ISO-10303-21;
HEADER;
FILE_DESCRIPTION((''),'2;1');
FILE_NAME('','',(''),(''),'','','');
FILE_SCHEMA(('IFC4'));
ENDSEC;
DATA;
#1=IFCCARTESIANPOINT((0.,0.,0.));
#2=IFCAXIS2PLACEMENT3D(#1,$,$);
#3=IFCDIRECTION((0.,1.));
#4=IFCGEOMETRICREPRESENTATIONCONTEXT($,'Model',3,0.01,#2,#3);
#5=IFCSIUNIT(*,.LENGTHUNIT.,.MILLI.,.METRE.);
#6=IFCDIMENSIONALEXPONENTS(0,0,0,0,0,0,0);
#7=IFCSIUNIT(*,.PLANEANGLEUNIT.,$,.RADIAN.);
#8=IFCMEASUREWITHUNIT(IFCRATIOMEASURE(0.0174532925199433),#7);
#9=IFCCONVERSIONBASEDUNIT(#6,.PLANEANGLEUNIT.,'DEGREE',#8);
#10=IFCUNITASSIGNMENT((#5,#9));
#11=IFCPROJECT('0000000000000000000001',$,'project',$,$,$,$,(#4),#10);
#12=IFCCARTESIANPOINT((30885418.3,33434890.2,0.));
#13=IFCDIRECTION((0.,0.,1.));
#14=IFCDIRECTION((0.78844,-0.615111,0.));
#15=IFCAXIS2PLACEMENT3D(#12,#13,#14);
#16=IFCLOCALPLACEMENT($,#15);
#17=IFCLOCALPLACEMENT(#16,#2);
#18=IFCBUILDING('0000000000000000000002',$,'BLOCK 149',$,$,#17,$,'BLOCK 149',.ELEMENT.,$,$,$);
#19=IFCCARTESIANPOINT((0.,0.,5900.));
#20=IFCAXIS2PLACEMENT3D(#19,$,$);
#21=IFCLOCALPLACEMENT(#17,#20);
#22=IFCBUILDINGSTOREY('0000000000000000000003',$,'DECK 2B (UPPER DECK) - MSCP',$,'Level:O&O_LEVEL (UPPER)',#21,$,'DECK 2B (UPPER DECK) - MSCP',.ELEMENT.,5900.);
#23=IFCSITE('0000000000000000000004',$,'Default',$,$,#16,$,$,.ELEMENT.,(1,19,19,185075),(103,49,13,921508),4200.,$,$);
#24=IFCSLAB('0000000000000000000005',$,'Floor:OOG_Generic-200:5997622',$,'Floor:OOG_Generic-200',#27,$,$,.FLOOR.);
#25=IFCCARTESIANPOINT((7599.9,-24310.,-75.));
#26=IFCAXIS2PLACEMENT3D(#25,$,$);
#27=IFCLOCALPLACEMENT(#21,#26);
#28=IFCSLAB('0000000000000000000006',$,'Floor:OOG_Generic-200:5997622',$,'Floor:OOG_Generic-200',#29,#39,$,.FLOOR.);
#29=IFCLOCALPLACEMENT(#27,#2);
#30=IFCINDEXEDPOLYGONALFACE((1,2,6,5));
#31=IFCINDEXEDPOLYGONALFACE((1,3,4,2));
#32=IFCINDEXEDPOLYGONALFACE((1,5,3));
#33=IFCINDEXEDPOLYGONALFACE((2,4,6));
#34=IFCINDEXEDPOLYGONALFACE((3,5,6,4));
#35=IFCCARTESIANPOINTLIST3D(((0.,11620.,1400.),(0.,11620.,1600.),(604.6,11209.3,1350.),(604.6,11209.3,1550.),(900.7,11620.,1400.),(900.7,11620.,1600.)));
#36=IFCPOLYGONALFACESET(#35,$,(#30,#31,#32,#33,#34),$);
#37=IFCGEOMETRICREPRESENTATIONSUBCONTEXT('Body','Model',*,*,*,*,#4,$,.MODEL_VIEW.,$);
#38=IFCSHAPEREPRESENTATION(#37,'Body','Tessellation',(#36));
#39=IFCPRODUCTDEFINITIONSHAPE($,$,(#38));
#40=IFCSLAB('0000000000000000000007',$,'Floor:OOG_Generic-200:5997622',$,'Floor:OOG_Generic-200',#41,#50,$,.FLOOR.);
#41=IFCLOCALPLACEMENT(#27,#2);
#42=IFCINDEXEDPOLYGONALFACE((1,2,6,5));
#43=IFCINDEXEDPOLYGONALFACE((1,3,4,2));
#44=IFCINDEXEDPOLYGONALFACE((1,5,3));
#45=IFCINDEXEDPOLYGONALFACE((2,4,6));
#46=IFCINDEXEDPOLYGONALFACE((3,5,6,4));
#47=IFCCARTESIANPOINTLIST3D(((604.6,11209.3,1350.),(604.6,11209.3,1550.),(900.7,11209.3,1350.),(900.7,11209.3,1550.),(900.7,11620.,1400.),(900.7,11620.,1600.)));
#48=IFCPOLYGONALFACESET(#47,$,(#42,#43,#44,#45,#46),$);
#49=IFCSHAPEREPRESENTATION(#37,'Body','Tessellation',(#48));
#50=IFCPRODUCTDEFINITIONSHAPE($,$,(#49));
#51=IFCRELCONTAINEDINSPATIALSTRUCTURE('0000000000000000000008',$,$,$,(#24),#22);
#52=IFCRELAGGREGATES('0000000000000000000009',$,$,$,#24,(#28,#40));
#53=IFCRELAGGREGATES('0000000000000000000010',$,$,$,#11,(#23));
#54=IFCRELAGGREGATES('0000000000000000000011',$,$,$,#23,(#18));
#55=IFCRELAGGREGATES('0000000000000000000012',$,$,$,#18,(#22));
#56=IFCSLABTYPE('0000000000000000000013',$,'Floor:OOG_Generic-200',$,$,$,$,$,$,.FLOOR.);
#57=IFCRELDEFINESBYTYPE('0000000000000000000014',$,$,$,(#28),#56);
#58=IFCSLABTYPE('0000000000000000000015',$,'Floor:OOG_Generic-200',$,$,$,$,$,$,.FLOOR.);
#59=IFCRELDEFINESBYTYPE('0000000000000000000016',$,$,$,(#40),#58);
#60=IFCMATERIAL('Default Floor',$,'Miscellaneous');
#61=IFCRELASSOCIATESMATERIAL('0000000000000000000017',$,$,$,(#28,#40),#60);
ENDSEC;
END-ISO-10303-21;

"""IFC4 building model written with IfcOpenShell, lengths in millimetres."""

from ifc_helpers import new_model, entity, si_unit, converted_unit, direction, frame, origin, place, context, subcontext, project, spatial, indexed_curve, outline, extrude, material, type_object, element, aggregate, save


model = new_model("IFC4")

# Units and contexts
model_context = context("Model", 3, precision=0.01, world=origin(), true_north=direction((0.0, 1.0)))
body_context = subcontext(model_context, "Body", "Model", "MODEL_VIEW")
ifc_project = project(units=[si_unit("LENGTHUNIT", "METRE", prefix="MILLI"), converted_unit("PLANEANGLEUNIT", "DEGREE", entity("IfcRatioMeasure", 0.0174532925199433), si_unit("PLANEANGLEUNIT", "RADIAN"), dimensions=[0, 0, 0, 0, 0, 0, 0])], contexts=[model_context])

# Site, building, storey
site_placement = place(None, frame((30885418.3, 33434890.2, 0.0), z_axis=(0.0, 0.0, 1.0), x_axis=(0.78844, -0.615111, 0.0)))
site = spatial("IfcSite", under=ifc_project, at=site_placement, Name="Default", CompositionType="ELEMENT", RefLatitude=(1, 19, 19, 185075), RefLongitude=(103, 49, 13, 921508), RefElevation=4200.0)
building_placement = place(site_placement, origin())
building = spatial("IfcBuilding", under=site, at=building_placement, Name="BLOCK 149", LongName="BLOCK 149", CompositionType="ELEMENT")
storey_placement = place(building_placement, frame((0.0, 0.0, 5900.0)))
storey = spatial("IfcBuildingStorey", under=building, at=storey_placement, Name="DECK 2B (UPPER DECK) - MSCP", ObjectType="Level:O&O_LEVEL (UPPER)", LongName="DECK 2B (UPPER DECK) - MSCP", CompositionType="ELEMENT", Elevation=5900.0)

# Slabs
ifc_material_1 = material(Name="Default Floor", Category="Miscellaneous")
slab_1_placement = place(storey_placement, frame((7599.9, -24310.0, -75.0)))
slab_1 = element("IfcSlab", 1, at=slab_1_placement, inside=storey, Name="Floor:OOG_Generic-200:5997622", ObjectType="Floor:OOG_Generic-200", PredefinedType="FLOOR")
slab_type_1 = type_object("IfcSlabType", Name="Floor:OOG_Generic-200", PredefinedType="FLOOR")
slab_2_placement = place(slab_1_placement, origin())
slab_2 = element("IfcSlab", 2, at=slab_2_placement, type_object=slab_type_1, material=ifc_material_1, Name="Floor:OOG_Generic-200:5997622", ObjectType="Floor:OOG_Generic-200", PredefinedType="FLOOR", context=body_context, shape_type="SweptSolid", body=[
    extrude(outline(indexed_curve([(-450.3, 0.0), (154.2, -413.8), (450.3, 0.0), (-450.3, 0.0)], self_intersect=False)), frame((450.3, 11620.0, 1600.0), z_axis=(0.0, -0.120838, 0.992672), x_axis=(1.0, 0.0, 0.0)), (0.0, -0.120838, -0.992672), 200.0),
])
slab_type_2 = type_object("IfcSlabType", Name="Floor:OOG_Generic-200", PredefinedType="FLOOR")
slab_3_placement = place(slab_1_placement, origin())
slab_3 = element("IfcSlab", 3, at=slab_3_placement, type_object=slab_type_2, material=ifc_material_1, Name="Floor:OOG_Generic-200:5997622", ObjectType="Floor:OOG_Generic-200", PredefinedType="FLOOR", context=body_context, shape_type="SweptSolid", body=[
    extrude(outline(indexed_curve([(-148.1, -206.9), (148.1, -206.9), (148.1, 206.9), (-148.1, -206.9)], self_intersect=False)), frame((752.6, 11414.6, 1575.0), z_axis=(0.0, -0.120838, 0.992672), x_axis=(1.0, 0.0, 0.0)), (0.0, -0.120838, -0.992672), 200.0),
])
aggregate(slab_1, [slab_2, slab_3])

save(model, "model.ifc")
